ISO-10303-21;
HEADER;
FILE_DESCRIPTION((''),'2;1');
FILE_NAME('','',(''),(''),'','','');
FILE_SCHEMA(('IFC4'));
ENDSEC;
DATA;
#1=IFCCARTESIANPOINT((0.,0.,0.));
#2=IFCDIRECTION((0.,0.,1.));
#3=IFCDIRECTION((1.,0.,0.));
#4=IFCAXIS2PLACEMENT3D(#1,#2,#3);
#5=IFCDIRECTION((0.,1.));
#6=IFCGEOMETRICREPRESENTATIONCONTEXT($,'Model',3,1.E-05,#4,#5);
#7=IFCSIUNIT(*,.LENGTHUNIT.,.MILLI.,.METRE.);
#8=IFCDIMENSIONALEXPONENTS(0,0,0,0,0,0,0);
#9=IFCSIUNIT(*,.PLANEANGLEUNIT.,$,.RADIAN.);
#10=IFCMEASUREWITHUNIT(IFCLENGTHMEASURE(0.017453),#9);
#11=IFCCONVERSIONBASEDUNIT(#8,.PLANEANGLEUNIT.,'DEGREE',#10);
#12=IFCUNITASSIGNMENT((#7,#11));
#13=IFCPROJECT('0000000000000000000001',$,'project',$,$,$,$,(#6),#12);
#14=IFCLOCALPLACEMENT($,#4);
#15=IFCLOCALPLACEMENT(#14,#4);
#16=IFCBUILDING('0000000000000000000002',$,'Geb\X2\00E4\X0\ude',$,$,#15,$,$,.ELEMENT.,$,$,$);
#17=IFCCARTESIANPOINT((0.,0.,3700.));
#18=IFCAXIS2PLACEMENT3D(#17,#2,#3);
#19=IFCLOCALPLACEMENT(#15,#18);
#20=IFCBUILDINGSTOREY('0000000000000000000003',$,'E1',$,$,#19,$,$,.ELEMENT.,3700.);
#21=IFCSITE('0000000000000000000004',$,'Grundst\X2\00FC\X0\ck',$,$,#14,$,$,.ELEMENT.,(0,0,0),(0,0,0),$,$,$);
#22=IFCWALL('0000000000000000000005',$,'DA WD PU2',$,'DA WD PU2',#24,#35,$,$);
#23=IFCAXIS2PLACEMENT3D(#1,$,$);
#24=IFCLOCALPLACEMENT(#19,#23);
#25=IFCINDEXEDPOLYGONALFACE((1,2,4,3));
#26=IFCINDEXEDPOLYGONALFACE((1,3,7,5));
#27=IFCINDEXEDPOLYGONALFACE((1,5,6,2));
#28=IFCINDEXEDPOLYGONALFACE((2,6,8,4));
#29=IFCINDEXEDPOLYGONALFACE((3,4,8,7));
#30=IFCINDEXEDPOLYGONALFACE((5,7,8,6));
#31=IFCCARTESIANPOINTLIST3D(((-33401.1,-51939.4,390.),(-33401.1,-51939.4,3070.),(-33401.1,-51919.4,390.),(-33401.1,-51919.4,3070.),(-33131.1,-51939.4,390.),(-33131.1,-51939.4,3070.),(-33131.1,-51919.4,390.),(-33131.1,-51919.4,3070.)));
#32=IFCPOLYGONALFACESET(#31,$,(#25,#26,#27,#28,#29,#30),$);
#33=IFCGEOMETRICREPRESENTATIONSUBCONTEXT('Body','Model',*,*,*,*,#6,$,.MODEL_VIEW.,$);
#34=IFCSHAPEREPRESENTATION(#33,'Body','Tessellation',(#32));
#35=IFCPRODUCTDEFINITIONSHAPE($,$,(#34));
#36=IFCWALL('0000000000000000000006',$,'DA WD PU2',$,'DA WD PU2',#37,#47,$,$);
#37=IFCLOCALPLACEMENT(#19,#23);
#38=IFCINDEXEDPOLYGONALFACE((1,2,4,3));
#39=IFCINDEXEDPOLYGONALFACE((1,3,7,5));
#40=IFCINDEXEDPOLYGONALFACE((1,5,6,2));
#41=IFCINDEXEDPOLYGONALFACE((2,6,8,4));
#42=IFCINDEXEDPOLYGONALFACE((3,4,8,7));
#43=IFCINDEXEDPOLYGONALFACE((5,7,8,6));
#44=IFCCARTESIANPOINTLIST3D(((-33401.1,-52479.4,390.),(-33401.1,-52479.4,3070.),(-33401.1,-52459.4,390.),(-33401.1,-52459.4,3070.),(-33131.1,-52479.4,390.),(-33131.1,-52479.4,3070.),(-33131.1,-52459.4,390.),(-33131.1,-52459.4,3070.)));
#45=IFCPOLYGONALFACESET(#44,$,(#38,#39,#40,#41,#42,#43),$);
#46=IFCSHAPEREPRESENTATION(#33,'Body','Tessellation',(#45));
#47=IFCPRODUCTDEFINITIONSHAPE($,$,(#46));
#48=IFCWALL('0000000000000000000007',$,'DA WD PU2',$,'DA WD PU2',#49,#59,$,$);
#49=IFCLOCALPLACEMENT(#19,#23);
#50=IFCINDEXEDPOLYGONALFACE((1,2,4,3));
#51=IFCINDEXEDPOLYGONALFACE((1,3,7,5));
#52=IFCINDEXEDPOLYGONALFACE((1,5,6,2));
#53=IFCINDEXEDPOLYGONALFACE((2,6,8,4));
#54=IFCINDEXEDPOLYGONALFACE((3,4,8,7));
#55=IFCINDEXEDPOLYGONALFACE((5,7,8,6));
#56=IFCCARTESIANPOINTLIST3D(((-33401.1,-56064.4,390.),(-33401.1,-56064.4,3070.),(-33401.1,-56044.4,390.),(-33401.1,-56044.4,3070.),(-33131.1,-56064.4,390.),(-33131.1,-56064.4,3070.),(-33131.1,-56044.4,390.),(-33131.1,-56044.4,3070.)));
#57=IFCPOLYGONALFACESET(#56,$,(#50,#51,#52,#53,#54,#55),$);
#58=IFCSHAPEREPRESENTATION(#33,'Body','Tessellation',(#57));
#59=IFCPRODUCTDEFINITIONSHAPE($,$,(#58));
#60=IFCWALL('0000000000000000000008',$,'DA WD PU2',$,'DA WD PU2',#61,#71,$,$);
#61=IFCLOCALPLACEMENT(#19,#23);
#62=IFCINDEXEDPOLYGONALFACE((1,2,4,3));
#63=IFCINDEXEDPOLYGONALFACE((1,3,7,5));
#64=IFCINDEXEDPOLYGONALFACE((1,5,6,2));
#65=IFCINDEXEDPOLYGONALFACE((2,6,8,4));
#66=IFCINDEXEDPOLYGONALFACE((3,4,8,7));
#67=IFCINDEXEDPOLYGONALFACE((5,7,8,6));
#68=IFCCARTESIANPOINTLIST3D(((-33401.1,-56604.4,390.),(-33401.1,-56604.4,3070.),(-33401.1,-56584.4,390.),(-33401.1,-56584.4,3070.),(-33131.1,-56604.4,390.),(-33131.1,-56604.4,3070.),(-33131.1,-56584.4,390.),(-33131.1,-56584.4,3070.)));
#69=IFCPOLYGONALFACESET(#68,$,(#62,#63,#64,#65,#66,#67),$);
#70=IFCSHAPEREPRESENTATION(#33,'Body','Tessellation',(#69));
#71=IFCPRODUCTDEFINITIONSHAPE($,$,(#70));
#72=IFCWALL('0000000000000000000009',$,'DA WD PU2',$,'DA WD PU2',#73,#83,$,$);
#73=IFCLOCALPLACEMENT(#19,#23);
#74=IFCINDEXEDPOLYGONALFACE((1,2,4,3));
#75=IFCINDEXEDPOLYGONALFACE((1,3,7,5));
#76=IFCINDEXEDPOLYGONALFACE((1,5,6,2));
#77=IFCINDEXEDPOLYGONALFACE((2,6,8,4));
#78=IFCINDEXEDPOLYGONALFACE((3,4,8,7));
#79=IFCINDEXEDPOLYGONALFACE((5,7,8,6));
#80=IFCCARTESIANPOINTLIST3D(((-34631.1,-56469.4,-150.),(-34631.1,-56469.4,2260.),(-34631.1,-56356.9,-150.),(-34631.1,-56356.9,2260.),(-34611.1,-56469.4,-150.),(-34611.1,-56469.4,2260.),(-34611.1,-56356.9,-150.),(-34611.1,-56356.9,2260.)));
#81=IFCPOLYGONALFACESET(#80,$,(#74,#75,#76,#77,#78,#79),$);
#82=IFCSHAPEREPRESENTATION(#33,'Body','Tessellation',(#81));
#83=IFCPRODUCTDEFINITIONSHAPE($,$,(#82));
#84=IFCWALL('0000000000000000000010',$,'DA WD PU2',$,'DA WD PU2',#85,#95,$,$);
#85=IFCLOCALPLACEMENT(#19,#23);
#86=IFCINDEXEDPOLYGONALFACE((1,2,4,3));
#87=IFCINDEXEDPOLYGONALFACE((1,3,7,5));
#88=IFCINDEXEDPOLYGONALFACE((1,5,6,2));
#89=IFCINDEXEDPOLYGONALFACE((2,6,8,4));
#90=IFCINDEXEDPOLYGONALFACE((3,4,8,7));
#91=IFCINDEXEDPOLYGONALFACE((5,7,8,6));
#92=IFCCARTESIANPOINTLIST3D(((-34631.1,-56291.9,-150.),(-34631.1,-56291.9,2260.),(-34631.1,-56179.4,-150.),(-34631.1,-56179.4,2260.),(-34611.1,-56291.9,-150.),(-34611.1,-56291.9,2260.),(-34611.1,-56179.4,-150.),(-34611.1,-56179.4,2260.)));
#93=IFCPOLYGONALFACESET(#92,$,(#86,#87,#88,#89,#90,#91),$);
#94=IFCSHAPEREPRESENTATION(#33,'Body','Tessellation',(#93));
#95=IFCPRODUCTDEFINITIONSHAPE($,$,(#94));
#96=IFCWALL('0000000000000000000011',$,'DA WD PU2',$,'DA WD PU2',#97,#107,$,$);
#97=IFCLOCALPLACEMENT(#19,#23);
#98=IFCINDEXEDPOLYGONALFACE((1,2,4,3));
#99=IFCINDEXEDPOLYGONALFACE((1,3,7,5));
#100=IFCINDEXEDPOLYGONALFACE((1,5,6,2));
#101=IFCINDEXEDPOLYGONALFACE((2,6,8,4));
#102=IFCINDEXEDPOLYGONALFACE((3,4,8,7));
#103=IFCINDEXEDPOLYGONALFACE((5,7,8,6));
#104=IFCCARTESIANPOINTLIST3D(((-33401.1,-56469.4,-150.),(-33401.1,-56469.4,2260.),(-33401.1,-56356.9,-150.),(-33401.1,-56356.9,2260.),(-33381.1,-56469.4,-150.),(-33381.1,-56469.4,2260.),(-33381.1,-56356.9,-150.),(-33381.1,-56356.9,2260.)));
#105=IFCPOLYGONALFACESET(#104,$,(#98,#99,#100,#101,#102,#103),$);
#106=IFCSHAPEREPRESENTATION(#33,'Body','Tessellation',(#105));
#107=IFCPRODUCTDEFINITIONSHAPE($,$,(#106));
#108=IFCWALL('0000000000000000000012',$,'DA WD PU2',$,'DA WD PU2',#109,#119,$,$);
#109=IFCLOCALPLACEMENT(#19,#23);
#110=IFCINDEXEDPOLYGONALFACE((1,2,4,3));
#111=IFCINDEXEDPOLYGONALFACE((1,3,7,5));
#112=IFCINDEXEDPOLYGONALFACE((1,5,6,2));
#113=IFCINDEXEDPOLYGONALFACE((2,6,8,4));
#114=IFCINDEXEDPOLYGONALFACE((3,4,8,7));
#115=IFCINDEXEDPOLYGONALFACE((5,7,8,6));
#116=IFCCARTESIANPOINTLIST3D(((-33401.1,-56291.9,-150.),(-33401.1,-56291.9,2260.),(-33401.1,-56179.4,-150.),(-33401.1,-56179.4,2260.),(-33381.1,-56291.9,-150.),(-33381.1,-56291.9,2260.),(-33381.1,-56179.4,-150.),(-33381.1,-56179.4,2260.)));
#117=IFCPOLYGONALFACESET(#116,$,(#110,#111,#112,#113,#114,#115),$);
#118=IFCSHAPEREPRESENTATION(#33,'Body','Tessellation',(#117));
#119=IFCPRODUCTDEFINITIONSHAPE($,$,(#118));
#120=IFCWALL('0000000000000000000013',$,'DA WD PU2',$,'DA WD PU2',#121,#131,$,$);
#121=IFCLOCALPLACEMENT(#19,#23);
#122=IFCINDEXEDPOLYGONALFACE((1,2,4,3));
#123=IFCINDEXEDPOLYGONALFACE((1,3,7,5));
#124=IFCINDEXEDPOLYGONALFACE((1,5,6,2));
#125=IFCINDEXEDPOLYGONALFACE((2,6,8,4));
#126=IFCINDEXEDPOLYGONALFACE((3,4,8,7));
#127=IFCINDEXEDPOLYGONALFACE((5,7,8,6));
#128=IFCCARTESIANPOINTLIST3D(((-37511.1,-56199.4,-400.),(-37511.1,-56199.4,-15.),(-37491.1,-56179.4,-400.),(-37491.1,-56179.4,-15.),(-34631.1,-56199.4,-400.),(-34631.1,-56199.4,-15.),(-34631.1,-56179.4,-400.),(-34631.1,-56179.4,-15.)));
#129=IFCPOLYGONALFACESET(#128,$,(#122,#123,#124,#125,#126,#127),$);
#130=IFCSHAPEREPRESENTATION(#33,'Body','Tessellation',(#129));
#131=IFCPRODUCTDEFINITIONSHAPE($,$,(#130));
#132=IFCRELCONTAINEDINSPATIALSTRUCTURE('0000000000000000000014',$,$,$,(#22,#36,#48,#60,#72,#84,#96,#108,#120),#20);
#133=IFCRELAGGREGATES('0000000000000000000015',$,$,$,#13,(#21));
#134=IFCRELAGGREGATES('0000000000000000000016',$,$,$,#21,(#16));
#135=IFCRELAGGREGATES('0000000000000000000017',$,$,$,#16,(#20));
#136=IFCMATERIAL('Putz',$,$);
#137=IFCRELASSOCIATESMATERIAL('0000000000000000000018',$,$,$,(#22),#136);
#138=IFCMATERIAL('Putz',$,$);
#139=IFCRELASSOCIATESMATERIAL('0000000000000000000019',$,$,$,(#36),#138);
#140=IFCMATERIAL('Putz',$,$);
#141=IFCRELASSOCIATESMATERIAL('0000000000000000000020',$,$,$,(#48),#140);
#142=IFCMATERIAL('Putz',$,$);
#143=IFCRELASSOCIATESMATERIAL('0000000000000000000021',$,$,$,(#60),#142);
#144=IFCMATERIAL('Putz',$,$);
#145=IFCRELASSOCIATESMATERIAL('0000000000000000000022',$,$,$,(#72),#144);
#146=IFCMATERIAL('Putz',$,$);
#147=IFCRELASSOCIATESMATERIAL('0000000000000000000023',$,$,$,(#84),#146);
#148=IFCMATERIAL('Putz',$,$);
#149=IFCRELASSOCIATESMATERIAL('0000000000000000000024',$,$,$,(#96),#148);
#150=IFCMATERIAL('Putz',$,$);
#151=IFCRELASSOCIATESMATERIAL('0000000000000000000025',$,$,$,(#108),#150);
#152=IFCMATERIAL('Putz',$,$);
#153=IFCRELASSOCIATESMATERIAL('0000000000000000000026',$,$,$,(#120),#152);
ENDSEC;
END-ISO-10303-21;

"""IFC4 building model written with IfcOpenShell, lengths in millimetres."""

from ifc_helpers import new_model, entity, si_unit, converted_unit, direction, frame, origin_with_axes, place, context, subcontext, project, spatial, line, indexed_curve, outline, extrude, material, element, save


model = new_model("IFC4")

# Units and contexts
model_context = context("Model", 3, precision=1e-05, world=origin_with_axes(), true_north=direction((0.0, 1.0)))
body_context = subcontext(model_context, "Body", "Model", "MODEL_VIEW")
ifc_project = project(units=[si_unit("LENGTHUNIT", "METRE", prefix="MILLI"), converted_unit("PLANEANGLEUNIT", "DEGREE", entity("IfcLengthMeasure", 0.017453), si_unit("PLANEANGLEUNIT", "RADIAN"), dimensions=[0, 0, 0, 0, 0, 0, 0])], contexts=[model_context])

# Site, building, storey
site_placement = place(None, origin_with_axes())
site = spatial("IfcSite", under=ifc_project, at=site_placement, Name="Grundstück", CompositionType="ELEMENT", RefLatitude=(0, 0, 0), RefLongitude=(0, 0, 0))
building_placement = place(site_placement, origin_with_axes())
building = spatial("IfcBuilding", under=site, at=building_placement, Name="Gebäude", CompositionType="ELEMENT")
storey_placement = place(building_placement, frame((0.0, 0.0, 3700.0), z_axis=(0.0, 0.0, 1.0), x_axis=(1.0, 0.0, 0.0)))
storey = spatial("IfcBuildingStorey", under=building, at=storey_placement, Name="E1", CompositionType="ELEMENT", Elevation=3700.0)

# Walls
ifc_material_1 = material(Name="Putz")
wall_1_placement = place(storey_placement, frame((-33401.1, -51929.4, 390.0), z_axis=(0.0, 0.0, 1.0), x_axis=(1.0, 0.0, 0.0)))
element("IfcWall", 1, at=wall_1_placement, inside=storey, material=ifc_material_1, Name="DA WD PU2", ObjectType="DA WD PU2", context=body_context, shape_type="SweptSolid", body=[
    extrude(outline(indexed_curve([(0.0, -10.0), (0.0, 10.0), (270.0, 10.0), (270.0, -10.0)], segments=[line(1, 2), line(2, 3), line(3, 4), line(4, 1)])), origin_with_axes(), (0.0, 0.0, 1.0), 2680.0),
])
ifc_material_2 = material(Name="Putz")
wall_2_placement = place(storey_placement, frame((-33401.1, -52469.4, 390.0), z_axis=(0.0, 0.0, 1.0), x_axis=(1.0, 0.0, 0.0)))
element("IfcWall", 2, at=wall_2_placement, inside=storey, material=ifc_material_2, Name="DA WD PU2", ObjectType="DA WD PU2", context=body_context, shape_type="SweptSolid", body=[
    extrude(outline(indexed_curve([(0.0, -10.0), (0.0, 10.0), (270.0, 10.0), (270.0, -10.0)], segments=[line(1, 2), line(2, 3), line(3, 4), line(4, 1)])), origin_with_axes(), (0.0, 0.0, 1.0), 2680.0),
])
ifc_material_3 = material(Name="Putz")
wall_3_placement = place(storey_placement, frame((-33401.1, -56054.4, 390.0), z_axis=(0.0, 0.0, 1.0), x_axis=(1.0, 0.0, 0.0)))
element("IfcWall", 3, at=wall_3_placement, inside=storey, material=ifc_material_3, Name="DA WD PU2", ObjectType="DA WD PU2", context=body_context, shape_type="SweptSolid", body=[
    extrude(outline(indexed_curve([(0.0, -10.0), (0.0, 10.0), (270.0, 10.0), (270.0, -10.0)], segments=[line(1, 2), line(2, 3), line(3, 4), line(4, 1)])), origin_with_axes(), (0.0, 0.0, 1.0), 2680.0),
])
ifc_material_4 = material(Name="Putz")
wall_4_placement = place(storey_placement, frame((-33401.1, -56594.4, 390.0), z_axis=(0.0, 0.0, 1.0), x_axis=(1.0, 0.0, 0.0)))
element("IfcWall", 4, at=wall_4_placement, inside=storey, material=ifc_material_4, Name="DA WD PU2", ObjectType="DA WD PU2", context=body_context, shape_type="SweptSolid", body=[
    extrude(outline(indexed_curve([(0.0, -10.0), (0.0, 10.0), (270.0, 10.0), (270.0, -10.0)], segments=[line(1, 2), line(2, 3), line(3, 4), line(4, 1)])), origin_with_axes(), (0.0, 0.0, 1.0), 2680.0),
])
ifc_material_5 = material(Name="Putz")
wall_5_placement = place(storey_placement, frame((-34621.1, -56469.4, -150.0), z_axis=(0.0, 0.0, 1.0), x_axis=(0.0, 1.0, 0.0)))
element("IfcWall", 5, at=wall_5_placement, inside=storey, material=ifc_material_5, Name="DA WD PU2", ObjectType="DA WD PU2", context=body_context, shape_type="SweptSolid", body=[
    extrude(outline(indexed_curve([(0.0, -10.0), (0.0, 10.0), (112.5, 10.0), (112.5, -10.0)], segments=[line(1, 2), line(2, 3), line(3, 4), line(4, 1)])), origin_with_axes(), (0.0, 0.0, 1.0), 2410.0),
])
ifc_material_6 = material(Name="Putz")
wall_6_placement = place(storey_placement, frame((-34621.1, -56291.9, -150.0), z_axis=(0.0, 0.0, 1.0), x_axis=(0.0, 1.0, 0.0)))
element("IfcWall", 6, at=wall_6_placement, inside=storey, material=ifc_material_6, Name="DA WD PU2", ObjectType="DA WD PU2", context=body_context, shape_type="SweptSolid", body=[
    extrude(outline(indexed_curve([(0.0, -10.0), (0.0, 10.0), (112.5, 10.0), (112.5, -10.0)], segments=[line(1, 2), line(2, 3), line(3, 4), line(4, 1)])), origin_with_axes(), (0.0, 0.0, 1.0), 2410.0),
])
ifc_material_7 = material(Name="Putz")
wall_7_placement = place(storey_placement, frame((-33391.1, -56469.4, -150.0), z_axis=(0.0, 0.0, 1.0), x_axis=(0.0, 1.0, 0.0)))
element("IfcWall", 7, at=wall_7_placement, inside=storey, material=ifc_material_7, Name="DA WD PU2", ObjectType="DA WD PU2", context=body_context, shape_type="SweptSolid", body=[
    extrude(outline(indexed_curve([(0.0, -10.0), (0.0, 10.0), (112.5, 10.0), (112.5, -10.0)], segments=[line(1, 2), line(2, 3), line(3, 4), line(4, 1)])), origin_with_axes(), (0.0, 0.0, 1.0), 2410.0),
])
ifc_material_8 = material(Name="Putz")
wall_8_placement = place(storey_placement, frame((-33391.1, -56291.9, -150.0), z_axis=(0.0, 0.0, 1.0), x_axis=(0.0, 1.0, 0.0)))
element("IfcWall", 8, at=wall_8_placement, inside=storey, material=ifc_material_8, Name="DA WD PU2", ObjectType="DA WD PU2", context=body_context, shape_type="SweptSolid", body=[
    extrude(outline(indexed_curve([(0.0, -10.0), (0.0, 10.0), (112.5, 10.0), (112.5, -10.0)], segments=[line(1, 2), line(2, 3), line(3, 4), line(4, 1)])), origin_with_axes(), (0.0, 0.0, 1.0), 2410.0),
])
ifc_material_9 = material(Name="Putz")
wall_9_placement = place(storey_placement, frame((-34631.1, -56189.4, -400.0), z_axis=(0.0, 0.0, 1.0), x_axis=(-1.0, 0.0, 0.0)))
element("IfcWall", 9, at=wall_9_placement, inside=storey, material=ifc_material_9, Name="DA WD PU2", ObjectType="DA WD PU2", context=body_context, shape_type="SweptSolid", body=[
    extrude(outline(indexed_curve([(0.0, -10.0), (0.0, 10.0), (2880.0, 10.0), (2860.0, -10.0)], segments=[line(1, 2), line(2, 3), line(3, 4), line(4, 1)])), origin_with_axes(), (0.0, 0.0, 1.0), 385.0),
])

save(model, "model.ifc")
